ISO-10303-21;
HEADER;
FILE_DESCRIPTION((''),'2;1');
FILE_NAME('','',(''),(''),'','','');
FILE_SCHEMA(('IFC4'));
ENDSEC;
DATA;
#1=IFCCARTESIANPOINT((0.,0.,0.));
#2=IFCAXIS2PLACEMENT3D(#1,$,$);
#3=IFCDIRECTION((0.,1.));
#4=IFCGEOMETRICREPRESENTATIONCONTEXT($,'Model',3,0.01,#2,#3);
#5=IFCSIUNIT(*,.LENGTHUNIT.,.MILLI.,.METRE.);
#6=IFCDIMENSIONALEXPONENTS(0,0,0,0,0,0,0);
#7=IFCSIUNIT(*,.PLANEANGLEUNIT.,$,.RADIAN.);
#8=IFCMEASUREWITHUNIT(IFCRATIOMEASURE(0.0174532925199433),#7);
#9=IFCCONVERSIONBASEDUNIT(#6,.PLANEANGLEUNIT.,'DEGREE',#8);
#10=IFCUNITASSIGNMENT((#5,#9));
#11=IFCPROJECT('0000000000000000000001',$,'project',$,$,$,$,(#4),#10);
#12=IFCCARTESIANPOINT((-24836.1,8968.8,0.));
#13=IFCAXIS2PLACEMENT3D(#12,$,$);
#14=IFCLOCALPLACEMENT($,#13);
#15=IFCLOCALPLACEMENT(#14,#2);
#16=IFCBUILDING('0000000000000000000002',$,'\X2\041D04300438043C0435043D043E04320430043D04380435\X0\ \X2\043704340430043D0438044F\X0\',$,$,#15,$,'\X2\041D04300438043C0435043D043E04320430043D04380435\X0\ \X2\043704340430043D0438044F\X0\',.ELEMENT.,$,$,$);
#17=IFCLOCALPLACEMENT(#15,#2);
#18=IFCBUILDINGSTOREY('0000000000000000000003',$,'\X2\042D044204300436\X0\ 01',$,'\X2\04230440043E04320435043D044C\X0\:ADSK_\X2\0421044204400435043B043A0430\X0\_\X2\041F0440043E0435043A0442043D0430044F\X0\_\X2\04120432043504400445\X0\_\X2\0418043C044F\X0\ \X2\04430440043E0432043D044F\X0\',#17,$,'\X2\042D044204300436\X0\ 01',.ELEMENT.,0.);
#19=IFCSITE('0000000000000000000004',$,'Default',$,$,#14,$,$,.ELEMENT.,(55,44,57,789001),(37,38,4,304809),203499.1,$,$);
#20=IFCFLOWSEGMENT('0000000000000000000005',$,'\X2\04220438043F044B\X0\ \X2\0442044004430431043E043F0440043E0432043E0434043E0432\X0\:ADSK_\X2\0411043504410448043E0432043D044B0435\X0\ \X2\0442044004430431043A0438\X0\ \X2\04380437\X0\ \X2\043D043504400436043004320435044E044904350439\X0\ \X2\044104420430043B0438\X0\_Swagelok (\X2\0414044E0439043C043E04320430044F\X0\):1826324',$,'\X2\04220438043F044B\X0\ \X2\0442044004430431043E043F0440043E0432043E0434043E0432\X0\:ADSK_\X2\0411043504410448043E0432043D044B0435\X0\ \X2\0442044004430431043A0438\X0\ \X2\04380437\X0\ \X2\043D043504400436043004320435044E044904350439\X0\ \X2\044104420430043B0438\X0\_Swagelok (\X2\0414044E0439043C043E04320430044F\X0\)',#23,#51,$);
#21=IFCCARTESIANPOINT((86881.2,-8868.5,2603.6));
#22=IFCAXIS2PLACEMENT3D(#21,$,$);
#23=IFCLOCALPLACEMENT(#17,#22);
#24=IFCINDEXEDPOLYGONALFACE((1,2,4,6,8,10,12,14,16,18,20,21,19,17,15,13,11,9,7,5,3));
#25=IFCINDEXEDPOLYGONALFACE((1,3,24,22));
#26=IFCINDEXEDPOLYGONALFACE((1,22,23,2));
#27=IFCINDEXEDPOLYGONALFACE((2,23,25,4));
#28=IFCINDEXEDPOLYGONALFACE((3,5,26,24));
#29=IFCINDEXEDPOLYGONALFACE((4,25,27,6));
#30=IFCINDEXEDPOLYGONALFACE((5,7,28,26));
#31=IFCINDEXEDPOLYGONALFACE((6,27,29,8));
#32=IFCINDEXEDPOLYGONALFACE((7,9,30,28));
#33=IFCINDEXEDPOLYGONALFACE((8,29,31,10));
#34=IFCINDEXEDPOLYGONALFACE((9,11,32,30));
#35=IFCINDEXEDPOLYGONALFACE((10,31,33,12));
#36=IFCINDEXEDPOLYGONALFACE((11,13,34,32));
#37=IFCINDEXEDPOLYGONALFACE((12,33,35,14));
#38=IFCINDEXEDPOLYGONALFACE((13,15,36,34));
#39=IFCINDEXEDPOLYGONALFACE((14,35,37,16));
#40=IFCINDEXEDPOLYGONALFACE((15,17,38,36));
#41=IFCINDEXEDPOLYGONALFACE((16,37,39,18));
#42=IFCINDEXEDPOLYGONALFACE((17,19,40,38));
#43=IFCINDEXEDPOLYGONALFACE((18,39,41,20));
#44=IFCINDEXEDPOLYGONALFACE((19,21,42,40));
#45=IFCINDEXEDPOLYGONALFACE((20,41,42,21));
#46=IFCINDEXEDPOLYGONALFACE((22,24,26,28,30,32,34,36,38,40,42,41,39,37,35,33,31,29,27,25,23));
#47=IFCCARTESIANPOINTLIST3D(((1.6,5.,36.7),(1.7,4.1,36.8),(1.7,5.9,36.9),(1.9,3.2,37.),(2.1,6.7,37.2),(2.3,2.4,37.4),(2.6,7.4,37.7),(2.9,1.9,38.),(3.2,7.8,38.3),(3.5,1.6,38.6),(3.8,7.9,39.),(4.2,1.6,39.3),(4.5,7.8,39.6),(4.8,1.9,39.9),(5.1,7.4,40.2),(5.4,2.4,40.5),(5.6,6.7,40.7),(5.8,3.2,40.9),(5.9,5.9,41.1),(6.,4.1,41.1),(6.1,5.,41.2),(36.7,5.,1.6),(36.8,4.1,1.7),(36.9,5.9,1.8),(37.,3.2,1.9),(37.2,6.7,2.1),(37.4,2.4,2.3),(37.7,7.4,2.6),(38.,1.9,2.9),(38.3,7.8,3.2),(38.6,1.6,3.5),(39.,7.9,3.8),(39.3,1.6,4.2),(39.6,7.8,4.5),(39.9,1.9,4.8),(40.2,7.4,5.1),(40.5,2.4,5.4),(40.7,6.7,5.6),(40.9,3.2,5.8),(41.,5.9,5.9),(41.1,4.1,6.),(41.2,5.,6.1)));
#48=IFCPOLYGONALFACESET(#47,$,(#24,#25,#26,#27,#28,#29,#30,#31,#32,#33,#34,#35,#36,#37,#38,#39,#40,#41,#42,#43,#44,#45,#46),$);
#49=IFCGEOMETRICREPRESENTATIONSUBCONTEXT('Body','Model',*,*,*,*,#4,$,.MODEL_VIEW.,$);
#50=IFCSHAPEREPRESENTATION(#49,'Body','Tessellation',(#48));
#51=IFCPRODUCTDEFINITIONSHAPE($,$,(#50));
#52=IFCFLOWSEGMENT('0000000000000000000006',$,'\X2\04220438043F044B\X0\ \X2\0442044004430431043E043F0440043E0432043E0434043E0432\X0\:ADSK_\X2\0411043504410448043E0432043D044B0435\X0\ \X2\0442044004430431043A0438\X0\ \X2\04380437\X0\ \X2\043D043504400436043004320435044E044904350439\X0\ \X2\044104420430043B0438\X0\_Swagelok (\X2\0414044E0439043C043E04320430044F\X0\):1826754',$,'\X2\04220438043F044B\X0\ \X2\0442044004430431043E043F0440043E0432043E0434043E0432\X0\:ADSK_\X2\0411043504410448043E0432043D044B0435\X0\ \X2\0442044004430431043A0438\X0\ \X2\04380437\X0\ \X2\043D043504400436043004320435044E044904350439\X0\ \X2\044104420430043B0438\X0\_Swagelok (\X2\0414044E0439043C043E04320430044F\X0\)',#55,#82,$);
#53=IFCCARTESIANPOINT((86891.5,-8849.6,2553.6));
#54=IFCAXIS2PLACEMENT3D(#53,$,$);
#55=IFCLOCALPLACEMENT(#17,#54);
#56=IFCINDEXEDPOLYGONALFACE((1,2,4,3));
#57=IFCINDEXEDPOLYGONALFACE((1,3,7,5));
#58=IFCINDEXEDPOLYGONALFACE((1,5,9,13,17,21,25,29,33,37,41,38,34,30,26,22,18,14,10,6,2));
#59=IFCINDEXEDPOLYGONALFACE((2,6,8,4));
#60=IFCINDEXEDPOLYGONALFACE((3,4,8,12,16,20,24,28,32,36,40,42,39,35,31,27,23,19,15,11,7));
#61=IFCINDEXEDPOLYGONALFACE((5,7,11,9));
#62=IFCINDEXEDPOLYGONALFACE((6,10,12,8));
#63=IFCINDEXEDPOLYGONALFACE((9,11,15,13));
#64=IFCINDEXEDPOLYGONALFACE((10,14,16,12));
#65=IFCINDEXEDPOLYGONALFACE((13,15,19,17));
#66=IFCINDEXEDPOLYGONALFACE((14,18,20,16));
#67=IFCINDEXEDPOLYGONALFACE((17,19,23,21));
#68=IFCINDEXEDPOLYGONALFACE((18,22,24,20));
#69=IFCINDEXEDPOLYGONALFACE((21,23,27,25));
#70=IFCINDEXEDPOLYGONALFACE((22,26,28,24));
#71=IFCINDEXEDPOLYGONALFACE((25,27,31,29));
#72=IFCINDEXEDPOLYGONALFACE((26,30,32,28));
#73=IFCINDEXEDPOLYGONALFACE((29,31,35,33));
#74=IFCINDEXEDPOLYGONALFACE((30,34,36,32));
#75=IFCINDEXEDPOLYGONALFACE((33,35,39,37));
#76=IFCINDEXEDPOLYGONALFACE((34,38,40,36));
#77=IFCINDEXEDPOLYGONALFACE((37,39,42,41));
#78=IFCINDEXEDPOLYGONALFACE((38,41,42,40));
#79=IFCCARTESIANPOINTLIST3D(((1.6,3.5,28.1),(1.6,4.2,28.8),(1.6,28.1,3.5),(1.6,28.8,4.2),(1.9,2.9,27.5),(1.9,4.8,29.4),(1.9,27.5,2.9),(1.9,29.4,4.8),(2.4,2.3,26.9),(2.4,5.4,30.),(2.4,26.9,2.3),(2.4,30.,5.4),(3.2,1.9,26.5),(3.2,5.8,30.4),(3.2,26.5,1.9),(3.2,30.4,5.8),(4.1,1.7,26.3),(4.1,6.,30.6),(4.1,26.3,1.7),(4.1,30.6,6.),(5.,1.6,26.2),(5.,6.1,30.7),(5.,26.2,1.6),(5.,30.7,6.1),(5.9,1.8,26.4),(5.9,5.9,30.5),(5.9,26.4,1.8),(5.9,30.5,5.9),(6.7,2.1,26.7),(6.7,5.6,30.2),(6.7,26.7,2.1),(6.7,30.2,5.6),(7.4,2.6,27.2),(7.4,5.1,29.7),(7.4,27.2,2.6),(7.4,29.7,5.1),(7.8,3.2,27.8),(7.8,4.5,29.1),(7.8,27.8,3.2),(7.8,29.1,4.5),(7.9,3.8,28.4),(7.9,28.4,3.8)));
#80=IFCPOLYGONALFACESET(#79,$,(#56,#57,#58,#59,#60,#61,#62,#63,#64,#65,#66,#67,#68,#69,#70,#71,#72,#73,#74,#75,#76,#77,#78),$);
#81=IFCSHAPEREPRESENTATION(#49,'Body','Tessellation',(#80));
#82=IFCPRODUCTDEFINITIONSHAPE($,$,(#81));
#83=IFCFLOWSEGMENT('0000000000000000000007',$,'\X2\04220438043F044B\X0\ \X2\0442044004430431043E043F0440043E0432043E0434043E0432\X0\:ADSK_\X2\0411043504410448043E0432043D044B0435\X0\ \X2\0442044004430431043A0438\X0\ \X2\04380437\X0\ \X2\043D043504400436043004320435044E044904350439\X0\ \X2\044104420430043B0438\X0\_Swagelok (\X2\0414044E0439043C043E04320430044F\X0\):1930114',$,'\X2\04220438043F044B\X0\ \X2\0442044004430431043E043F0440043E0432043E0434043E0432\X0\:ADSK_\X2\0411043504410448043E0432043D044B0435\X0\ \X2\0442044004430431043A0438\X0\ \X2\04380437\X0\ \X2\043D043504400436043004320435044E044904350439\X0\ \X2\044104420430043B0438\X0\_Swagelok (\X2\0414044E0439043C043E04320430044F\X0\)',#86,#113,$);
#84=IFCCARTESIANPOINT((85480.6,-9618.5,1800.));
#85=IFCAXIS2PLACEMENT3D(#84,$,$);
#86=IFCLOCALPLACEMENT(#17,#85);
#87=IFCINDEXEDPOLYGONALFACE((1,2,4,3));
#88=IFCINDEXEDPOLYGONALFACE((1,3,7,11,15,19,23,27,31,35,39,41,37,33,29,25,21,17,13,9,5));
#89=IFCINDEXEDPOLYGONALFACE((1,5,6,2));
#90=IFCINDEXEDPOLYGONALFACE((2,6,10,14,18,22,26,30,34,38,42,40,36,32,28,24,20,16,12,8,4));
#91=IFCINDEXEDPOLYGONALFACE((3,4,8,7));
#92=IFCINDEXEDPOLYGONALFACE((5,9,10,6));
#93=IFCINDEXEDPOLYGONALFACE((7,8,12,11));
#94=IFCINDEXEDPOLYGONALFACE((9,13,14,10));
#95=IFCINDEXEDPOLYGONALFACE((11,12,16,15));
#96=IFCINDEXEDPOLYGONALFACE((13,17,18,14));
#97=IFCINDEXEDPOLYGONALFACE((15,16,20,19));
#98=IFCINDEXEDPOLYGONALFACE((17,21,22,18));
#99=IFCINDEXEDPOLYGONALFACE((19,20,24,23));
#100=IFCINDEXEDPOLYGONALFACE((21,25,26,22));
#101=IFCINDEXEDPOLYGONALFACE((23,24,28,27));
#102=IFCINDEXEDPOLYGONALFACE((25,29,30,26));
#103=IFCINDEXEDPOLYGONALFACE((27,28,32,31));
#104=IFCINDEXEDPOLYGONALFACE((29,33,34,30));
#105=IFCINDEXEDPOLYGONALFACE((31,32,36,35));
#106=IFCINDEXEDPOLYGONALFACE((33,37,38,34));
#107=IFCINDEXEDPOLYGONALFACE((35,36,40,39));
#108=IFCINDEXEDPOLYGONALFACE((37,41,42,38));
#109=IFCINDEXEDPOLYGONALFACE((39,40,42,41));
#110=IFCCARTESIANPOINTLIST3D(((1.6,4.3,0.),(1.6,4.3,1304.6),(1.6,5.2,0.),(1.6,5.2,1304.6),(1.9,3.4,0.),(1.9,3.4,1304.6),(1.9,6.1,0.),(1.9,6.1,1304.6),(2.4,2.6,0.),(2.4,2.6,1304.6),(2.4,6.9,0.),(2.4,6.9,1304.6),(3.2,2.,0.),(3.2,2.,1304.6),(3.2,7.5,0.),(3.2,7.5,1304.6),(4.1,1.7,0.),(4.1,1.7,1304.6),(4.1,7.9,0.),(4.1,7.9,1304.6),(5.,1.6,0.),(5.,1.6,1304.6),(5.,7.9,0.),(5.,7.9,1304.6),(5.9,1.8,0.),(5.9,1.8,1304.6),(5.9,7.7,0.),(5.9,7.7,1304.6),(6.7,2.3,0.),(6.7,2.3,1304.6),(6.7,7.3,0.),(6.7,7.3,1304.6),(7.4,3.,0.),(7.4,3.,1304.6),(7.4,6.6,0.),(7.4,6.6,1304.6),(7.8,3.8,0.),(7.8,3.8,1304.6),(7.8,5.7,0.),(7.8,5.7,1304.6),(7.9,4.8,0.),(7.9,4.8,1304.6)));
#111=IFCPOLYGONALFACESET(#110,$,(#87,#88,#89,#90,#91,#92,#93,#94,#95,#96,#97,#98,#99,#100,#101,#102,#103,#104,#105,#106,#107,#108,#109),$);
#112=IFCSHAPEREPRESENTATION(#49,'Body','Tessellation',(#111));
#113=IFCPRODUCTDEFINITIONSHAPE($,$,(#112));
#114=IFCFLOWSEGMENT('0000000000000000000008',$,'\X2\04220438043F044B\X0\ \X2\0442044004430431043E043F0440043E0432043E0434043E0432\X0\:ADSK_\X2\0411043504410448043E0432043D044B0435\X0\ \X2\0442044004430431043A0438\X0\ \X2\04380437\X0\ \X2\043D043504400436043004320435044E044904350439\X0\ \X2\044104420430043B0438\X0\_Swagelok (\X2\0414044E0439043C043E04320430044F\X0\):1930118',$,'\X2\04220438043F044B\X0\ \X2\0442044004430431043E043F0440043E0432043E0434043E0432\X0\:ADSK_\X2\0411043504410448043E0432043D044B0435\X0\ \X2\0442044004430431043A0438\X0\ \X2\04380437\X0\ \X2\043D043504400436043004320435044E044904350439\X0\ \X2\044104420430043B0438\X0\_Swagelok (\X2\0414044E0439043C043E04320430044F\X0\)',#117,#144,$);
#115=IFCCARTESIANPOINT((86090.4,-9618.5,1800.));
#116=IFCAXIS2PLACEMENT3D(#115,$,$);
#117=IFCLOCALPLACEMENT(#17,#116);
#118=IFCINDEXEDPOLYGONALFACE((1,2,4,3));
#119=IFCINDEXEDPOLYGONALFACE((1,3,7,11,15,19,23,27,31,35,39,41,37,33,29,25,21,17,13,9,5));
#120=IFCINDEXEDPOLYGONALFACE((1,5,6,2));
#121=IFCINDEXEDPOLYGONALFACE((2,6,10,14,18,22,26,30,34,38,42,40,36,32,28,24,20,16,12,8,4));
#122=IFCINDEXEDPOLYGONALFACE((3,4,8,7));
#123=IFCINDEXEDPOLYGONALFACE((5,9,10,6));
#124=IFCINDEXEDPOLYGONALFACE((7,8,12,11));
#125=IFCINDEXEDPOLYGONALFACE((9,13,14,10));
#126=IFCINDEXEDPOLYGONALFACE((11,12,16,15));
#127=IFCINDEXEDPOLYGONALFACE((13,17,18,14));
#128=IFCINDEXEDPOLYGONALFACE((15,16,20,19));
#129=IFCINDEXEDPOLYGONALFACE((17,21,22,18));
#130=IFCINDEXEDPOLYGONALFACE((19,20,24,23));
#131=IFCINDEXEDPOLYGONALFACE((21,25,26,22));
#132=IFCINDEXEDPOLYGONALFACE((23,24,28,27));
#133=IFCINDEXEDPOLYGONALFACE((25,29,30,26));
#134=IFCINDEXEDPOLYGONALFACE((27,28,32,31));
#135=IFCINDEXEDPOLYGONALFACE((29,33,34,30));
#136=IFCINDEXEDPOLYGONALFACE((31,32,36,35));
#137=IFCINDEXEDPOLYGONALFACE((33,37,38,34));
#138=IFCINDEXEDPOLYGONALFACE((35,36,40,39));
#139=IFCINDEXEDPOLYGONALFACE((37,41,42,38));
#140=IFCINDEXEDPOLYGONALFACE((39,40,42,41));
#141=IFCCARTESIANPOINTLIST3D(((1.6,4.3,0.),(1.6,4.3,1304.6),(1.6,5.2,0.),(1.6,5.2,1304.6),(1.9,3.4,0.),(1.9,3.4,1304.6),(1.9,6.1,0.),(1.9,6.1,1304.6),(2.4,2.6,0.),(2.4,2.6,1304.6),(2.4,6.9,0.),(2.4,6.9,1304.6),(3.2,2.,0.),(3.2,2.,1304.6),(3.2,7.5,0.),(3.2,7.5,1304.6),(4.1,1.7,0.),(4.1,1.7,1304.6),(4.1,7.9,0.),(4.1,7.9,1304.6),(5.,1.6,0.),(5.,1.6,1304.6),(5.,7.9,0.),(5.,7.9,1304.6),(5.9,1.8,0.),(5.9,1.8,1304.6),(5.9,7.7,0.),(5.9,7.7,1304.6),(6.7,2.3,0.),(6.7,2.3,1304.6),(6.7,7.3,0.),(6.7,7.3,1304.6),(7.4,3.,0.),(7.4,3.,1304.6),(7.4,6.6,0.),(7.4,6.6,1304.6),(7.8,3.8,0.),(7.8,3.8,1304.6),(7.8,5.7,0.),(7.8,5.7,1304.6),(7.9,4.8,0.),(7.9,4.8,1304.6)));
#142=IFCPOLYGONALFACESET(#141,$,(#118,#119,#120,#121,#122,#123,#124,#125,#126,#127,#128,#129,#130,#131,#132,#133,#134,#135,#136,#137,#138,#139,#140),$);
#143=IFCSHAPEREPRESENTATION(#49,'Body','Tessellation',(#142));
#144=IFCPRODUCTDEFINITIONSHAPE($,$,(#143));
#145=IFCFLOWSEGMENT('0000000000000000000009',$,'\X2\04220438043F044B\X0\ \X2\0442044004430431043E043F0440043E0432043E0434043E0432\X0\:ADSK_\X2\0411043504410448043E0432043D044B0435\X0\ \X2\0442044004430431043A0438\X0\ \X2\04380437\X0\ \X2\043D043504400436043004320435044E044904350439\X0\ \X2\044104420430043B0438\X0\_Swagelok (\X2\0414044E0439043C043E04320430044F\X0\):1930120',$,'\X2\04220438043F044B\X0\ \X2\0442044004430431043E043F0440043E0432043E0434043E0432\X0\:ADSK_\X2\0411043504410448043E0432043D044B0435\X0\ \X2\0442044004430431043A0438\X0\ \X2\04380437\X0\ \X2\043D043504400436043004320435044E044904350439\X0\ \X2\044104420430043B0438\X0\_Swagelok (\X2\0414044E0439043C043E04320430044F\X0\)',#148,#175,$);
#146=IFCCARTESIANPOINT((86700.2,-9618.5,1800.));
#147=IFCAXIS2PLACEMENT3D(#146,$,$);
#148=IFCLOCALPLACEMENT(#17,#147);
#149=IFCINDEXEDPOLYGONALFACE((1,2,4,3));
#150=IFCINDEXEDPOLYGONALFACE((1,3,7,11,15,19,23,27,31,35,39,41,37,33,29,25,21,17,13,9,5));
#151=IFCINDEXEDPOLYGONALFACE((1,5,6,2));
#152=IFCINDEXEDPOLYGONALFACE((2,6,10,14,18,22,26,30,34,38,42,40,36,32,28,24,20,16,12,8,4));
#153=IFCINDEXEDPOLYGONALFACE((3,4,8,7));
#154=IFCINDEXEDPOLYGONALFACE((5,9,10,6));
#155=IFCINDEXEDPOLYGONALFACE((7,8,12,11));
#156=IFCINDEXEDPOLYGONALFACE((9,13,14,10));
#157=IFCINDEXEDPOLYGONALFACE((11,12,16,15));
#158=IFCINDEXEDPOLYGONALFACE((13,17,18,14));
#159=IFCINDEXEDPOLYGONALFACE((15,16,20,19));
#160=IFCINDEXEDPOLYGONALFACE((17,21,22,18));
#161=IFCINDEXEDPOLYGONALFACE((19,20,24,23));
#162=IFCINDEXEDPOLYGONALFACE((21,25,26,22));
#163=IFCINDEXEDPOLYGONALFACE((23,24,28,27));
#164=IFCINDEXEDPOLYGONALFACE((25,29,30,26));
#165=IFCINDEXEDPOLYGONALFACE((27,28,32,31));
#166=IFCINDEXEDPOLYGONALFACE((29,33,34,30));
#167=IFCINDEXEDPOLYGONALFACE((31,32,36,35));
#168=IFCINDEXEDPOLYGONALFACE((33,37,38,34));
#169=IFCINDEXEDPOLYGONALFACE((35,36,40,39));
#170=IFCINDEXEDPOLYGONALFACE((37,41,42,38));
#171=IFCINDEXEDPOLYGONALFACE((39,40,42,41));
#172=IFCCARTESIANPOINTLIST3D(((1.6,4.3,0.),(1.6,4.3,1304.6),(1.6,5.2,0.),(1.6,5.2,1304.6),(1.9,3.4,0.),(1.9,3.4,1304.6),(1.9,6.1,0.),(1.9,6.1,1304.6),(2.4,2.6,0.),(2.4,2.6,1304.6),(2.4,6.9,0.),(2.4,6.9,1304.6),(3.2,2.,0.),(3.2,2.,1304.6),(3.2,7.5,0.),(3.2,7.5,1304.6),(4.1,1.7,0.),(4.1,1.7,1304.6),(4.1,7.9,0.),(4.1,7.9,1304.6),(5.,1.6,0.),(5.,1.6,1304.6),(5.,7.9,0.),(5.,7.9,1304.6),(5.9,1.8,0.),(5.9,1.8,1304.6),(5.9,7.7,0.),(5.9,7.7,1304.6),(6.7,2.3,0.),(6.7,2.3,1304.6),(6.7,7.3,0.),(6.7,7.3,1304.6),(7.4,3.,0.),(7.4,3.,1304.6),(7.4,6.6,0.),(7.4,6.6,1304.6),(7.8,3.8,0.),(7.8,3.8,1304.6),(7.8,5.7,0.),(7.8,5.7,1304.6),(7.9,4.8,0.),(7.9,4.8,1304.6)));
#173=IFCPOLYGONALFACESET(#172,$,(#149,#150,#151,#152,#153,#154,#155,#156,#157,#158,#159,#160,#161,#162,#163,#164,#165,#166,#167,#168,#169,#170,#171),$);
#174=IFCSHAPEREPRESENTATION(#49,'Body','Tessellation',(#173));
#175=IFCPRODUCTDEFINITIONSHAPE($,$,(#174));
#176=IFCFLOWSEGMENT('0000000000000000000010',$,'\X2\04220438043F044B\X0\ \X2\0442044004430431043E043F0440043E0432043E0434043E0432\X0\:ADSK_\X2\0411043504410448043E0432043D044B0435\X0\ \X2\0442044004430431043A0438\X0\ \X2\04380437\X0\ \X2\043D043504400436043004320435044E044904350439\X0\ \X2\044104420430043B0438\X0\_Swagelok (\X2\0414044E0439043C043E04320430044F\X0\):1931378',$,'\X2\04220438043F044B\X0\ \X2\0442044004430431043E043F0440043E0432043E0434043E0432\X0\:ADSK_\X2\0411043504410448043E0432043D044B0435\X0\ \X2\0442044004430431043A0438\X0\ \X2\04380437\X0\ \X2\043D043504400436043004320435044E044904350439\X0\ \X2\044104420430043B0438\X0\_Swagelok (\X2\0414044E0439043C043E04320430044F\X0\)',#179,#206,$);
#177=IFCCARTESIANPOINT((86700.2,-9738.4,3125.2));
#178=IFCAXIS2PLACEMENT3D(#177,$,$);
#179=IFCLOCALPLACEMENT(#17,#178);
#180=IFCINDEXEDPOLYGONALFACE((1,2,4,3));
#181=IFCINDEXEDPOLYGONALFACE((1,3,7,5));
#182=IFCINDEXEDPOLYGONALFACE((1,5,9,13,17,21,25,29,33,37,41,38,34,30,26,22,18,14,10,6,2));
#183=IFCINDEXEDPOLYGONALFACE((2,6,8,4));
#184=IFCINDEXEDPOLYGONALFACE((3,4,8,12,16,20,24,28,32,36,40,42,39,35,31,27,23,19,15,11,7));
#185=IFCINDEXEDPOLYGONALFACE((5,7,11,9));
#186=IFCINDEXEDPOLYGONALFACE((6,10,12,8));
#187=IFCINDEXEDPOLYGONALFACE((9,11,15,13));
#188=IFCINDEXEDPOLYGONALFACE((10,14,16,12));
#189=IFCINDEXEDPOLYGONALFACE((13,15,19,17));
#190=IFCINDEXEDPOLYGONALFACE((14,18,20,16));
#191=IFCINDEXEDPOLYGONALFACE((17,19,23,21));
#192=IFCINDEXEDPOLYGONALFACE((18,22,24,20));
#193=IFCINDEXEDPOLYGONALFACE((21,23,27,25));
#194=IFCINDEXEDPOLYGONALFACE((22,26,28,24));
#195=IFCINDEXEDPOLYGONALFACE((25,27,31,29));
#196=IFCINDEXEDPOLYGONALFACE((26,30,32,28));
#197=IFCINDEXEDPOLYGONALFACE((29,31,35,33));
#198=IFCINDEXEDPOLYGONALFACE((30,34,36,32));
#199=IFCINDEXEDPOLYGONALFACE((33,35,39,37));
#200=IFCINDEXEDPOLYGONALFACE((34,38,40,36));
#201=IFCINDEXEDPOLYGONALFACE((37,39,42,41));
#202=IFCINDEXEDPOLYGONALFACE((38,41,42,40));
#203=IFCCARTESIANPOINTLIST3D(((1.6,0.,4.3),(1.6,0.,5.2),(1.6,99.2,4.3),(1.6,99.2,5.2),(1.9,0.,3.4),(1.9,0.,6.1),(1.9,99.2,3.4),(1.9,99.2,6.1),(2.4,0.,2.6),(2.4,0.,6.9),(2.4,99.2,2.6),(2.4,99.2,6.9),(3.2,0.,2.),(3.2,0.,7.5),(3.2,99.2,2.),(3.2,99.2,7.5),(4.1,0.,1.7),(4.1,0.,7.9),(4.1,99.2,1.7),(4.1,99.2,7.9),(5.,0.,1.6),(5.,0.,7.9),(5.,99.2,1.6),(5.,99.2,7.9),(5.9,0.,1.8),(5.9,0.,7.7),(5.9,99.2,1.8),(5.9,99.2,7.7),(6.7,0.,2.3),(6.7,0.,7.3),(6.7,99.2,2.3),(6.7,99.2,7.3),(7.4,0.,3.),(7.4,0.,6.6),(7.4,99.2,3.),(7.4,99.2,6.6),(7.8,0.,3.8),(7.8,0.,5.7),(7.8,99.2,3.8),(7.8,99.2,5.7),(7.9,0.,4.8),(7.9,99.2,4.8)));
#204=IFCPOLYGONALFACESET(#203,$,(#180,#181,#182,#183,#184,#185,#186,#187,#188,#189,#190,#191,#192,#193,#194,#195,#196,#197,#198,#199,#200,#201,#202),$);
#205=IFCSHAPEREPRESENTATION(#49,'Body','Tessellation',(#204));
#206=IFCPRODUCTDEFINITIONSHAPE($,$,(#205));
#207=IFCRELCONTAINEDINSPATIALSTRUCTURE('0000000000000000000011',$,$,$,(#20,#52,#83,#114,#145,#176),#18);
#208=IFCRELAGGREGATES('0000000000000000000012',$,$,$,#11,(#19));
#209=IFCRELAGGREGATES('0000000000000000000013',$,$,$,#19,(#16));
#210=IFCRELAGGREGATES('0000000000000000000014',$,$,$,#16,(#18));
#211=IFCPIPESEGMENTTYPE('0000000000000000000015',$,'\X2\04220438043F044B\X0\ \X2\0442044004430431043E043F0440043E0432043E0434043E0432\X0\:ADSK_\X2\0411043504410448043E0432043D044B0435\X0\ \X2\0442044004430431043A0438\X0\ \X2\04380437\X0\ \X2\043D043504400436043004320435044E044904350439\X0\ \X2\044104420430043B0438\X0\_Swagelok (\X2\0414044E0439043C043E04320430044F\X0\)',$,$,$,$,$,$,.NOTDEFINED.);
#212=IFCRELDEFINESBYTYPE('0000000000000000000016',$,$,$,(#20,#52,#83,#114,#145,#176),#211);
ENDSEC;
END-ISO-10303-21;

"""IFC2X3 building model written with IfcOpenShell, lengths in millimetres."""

from ifc_helpers import new_model, entity, si_unit, converted_unit, direction, frame, origin, origin_2d_with_axis, place, context, subcontext, project, spatial, circle, extrude, type_object, element, save


model = new_model("IFC2X3")

# Units and contexts
model_context = context("Model", 3, precision=0.01, world=origin(), true_north=direction((0.0, 1.0)))
body_context = subcontext(model_context, "Body", "Model", "MODEL_VIEW")
ifc_project = project(units=[si_unit("LENGTHUNIT", "METRE", prefix="MILLI"), converted_unit("PLANEANGLEUNIT", "DEGREE", entity("IfcRatioMeasure", 0.0174532925199433), si_unit("PLANEANGLEUNIT", "RADIAN"), dimensions=[0, 0, 0, 0, 0, 0, 0])], contexts=[model_context])

# Site, building, storey
site_placement = place(None, frame((-24836.1, 8968.8, 0.0)))
site = spatial("IfcSite", under=ifc_project, at=site_placement, Name="Default", CompositionType="ELEMENT", RefLatitude=(55, 44, 57, 789001), RefLongitude=(37, 38, 4, 304809), RefElevation=203499.1)
building_placement = place(site_placement, origin())
building = spatial("IfcBuilding", under=site, at=building_placement, Name="Наименование здания", LongName="Наименование здания", CompositionType="ELEMENT")
storey_placement = place(building_placement, origin())
storey = spatial("IfcBuildingStorey", under=building, at=storey_placement, Name="Этаж 01", ObjectType="Уровень:ADSK_Стрелка_Проектная_Вверх_Имя уровня", LongName="Этаж 01", CompositionType="ELEMENT", Elevation=0.0)

# Flow segments
pipe_segment_type_1 = type_object("IfcPipeSegmentType", Name="Типы трубопроводов:ADSK_Бесшовные трубки из нержавеющей стали_Swagelok (Дюймовая)", PredefinedType="NOTDEFINED")
flow_segment_1_placement = place(storey_placement, frame((86881.2, -8868.5, 2603.6)))
element("IfcFlowSegment", 1, at=flow_segment_1_placement, inside=storey, type_object=pipe_segment_type_1, Name="Типы трубопроводов:ADSK_Бесшовные трубки из нержавеющей стали_Swagelok (Дюймовая):1826324", ObjectType="Типы трубопроводов:ADSK_Бесшовные трубки из нержавеющей стали_Swagelok (Дюймовая)", context=body_context, shape_type="SweptSolid", body=[
    extrude(circle(Radius=3.2, at=origin_2d_with_axis()), frame((39.0, 4.8, 3.8), z_axis=(-0.707107, 0.0, 0.707107), x_axis=(0.0, 1.0, 0.0)), (0.0, 0.0, 1.0), 49.7),
])
flow_segment_2_placement = place(storey_placement, frame((86891.5, -8849.6, 2553.6)))
element("IfcFlowSegment", 2, at=flow_segment_2_placement, inside=storey, type_object=pipe_segment_type_1, Name="Типы трубопроводов:ADSK_Бесшовные трубки из нержавеющей стали_Swagelok (Дюймовая):1826754", ObjectType="Типы трубопроводов:ADSK_Бесшовные трубки из нержавеющей стали_Swagelok (Дюймовая)", context=body_context, shape_type="SweptSolid", body=[
    extrude(circle(Radius=3.2, at=origin_2d_with_axis()), frame((4.8, 28.4, 3.8), z_axis=(0.0, -0.707107, 0.707107), x_axis=(1.0, 0.0, 0.0)), (0.0, 0.0, 1.0), 34.8),
])
for number, where, name in (
    (3, (85480.6, -9618.5, 1800.0), "Типы трубопроводов:ADSK_Бесшовные трубки из нержавеющей стали_Swagelok (Дюймовая):1930114"),
    (4, (86090.4, -9618.5, 1800.0), "Типы трубопроводов:ADSK_Бесшовные трубки из нержавеющей стали_Swagelok (Дюймовая):1930118"),
    (5, (86700.2, -9618.5, 1800.0), "Типы трубопроводов:ADSK_Бесшовные трубки из нержавеющей стали_Swagelok (Дюймовая):1930120"),
):
    element("IfcFlowSegment", number, at=place(storey_placement, frame(where)), inside=storey, type_object=pipe_segment_type_1, Name=name, ObjectType="Типы трубопроводов:ADSK_Бесшовные трубки из нержавеющей стали_Swagelok (Дюймовая)", context=body_context, shape_type="SweptSolid", body=[
        extrude(circle(Radius=3.2, at=origin_2d_with_axis()), frame((4.8, 4.8, 0.0)), (0.0, 0.0, 1.0), 1304.6),
    ])
flow_segment_3_placement = place(storey_placement, frame((86700.2, -9738.4, 3125.2)))
element("IfcFlowSegment", 6, at=flow_segment_3_placement, inside=storey, type_object=pipe_segment_type_1, Name="Типы трубопроводов:ADSK_Бесшовные трубки из нержавеющей стали_Swagelok (Дюймовая):1931378", ObjectType="Типы трубопроводов:ADSK_Бесшовные трубки из нержавеющей стали_Swagelok (Дюймовая)", context=body_context, shape_type="SweptSolid", body=[
    extrude(circle(Radius=3.2, at=origin_2d_with_axis()), frame((4.8, 0.0, 4.8), z_axis=(0.0, 1.0, 0.0), x_axis=(1.0, 0.0, 0.0)), (0.0, 0.0, 1.0), 99.2),
])

save(model, "model.ifc")
